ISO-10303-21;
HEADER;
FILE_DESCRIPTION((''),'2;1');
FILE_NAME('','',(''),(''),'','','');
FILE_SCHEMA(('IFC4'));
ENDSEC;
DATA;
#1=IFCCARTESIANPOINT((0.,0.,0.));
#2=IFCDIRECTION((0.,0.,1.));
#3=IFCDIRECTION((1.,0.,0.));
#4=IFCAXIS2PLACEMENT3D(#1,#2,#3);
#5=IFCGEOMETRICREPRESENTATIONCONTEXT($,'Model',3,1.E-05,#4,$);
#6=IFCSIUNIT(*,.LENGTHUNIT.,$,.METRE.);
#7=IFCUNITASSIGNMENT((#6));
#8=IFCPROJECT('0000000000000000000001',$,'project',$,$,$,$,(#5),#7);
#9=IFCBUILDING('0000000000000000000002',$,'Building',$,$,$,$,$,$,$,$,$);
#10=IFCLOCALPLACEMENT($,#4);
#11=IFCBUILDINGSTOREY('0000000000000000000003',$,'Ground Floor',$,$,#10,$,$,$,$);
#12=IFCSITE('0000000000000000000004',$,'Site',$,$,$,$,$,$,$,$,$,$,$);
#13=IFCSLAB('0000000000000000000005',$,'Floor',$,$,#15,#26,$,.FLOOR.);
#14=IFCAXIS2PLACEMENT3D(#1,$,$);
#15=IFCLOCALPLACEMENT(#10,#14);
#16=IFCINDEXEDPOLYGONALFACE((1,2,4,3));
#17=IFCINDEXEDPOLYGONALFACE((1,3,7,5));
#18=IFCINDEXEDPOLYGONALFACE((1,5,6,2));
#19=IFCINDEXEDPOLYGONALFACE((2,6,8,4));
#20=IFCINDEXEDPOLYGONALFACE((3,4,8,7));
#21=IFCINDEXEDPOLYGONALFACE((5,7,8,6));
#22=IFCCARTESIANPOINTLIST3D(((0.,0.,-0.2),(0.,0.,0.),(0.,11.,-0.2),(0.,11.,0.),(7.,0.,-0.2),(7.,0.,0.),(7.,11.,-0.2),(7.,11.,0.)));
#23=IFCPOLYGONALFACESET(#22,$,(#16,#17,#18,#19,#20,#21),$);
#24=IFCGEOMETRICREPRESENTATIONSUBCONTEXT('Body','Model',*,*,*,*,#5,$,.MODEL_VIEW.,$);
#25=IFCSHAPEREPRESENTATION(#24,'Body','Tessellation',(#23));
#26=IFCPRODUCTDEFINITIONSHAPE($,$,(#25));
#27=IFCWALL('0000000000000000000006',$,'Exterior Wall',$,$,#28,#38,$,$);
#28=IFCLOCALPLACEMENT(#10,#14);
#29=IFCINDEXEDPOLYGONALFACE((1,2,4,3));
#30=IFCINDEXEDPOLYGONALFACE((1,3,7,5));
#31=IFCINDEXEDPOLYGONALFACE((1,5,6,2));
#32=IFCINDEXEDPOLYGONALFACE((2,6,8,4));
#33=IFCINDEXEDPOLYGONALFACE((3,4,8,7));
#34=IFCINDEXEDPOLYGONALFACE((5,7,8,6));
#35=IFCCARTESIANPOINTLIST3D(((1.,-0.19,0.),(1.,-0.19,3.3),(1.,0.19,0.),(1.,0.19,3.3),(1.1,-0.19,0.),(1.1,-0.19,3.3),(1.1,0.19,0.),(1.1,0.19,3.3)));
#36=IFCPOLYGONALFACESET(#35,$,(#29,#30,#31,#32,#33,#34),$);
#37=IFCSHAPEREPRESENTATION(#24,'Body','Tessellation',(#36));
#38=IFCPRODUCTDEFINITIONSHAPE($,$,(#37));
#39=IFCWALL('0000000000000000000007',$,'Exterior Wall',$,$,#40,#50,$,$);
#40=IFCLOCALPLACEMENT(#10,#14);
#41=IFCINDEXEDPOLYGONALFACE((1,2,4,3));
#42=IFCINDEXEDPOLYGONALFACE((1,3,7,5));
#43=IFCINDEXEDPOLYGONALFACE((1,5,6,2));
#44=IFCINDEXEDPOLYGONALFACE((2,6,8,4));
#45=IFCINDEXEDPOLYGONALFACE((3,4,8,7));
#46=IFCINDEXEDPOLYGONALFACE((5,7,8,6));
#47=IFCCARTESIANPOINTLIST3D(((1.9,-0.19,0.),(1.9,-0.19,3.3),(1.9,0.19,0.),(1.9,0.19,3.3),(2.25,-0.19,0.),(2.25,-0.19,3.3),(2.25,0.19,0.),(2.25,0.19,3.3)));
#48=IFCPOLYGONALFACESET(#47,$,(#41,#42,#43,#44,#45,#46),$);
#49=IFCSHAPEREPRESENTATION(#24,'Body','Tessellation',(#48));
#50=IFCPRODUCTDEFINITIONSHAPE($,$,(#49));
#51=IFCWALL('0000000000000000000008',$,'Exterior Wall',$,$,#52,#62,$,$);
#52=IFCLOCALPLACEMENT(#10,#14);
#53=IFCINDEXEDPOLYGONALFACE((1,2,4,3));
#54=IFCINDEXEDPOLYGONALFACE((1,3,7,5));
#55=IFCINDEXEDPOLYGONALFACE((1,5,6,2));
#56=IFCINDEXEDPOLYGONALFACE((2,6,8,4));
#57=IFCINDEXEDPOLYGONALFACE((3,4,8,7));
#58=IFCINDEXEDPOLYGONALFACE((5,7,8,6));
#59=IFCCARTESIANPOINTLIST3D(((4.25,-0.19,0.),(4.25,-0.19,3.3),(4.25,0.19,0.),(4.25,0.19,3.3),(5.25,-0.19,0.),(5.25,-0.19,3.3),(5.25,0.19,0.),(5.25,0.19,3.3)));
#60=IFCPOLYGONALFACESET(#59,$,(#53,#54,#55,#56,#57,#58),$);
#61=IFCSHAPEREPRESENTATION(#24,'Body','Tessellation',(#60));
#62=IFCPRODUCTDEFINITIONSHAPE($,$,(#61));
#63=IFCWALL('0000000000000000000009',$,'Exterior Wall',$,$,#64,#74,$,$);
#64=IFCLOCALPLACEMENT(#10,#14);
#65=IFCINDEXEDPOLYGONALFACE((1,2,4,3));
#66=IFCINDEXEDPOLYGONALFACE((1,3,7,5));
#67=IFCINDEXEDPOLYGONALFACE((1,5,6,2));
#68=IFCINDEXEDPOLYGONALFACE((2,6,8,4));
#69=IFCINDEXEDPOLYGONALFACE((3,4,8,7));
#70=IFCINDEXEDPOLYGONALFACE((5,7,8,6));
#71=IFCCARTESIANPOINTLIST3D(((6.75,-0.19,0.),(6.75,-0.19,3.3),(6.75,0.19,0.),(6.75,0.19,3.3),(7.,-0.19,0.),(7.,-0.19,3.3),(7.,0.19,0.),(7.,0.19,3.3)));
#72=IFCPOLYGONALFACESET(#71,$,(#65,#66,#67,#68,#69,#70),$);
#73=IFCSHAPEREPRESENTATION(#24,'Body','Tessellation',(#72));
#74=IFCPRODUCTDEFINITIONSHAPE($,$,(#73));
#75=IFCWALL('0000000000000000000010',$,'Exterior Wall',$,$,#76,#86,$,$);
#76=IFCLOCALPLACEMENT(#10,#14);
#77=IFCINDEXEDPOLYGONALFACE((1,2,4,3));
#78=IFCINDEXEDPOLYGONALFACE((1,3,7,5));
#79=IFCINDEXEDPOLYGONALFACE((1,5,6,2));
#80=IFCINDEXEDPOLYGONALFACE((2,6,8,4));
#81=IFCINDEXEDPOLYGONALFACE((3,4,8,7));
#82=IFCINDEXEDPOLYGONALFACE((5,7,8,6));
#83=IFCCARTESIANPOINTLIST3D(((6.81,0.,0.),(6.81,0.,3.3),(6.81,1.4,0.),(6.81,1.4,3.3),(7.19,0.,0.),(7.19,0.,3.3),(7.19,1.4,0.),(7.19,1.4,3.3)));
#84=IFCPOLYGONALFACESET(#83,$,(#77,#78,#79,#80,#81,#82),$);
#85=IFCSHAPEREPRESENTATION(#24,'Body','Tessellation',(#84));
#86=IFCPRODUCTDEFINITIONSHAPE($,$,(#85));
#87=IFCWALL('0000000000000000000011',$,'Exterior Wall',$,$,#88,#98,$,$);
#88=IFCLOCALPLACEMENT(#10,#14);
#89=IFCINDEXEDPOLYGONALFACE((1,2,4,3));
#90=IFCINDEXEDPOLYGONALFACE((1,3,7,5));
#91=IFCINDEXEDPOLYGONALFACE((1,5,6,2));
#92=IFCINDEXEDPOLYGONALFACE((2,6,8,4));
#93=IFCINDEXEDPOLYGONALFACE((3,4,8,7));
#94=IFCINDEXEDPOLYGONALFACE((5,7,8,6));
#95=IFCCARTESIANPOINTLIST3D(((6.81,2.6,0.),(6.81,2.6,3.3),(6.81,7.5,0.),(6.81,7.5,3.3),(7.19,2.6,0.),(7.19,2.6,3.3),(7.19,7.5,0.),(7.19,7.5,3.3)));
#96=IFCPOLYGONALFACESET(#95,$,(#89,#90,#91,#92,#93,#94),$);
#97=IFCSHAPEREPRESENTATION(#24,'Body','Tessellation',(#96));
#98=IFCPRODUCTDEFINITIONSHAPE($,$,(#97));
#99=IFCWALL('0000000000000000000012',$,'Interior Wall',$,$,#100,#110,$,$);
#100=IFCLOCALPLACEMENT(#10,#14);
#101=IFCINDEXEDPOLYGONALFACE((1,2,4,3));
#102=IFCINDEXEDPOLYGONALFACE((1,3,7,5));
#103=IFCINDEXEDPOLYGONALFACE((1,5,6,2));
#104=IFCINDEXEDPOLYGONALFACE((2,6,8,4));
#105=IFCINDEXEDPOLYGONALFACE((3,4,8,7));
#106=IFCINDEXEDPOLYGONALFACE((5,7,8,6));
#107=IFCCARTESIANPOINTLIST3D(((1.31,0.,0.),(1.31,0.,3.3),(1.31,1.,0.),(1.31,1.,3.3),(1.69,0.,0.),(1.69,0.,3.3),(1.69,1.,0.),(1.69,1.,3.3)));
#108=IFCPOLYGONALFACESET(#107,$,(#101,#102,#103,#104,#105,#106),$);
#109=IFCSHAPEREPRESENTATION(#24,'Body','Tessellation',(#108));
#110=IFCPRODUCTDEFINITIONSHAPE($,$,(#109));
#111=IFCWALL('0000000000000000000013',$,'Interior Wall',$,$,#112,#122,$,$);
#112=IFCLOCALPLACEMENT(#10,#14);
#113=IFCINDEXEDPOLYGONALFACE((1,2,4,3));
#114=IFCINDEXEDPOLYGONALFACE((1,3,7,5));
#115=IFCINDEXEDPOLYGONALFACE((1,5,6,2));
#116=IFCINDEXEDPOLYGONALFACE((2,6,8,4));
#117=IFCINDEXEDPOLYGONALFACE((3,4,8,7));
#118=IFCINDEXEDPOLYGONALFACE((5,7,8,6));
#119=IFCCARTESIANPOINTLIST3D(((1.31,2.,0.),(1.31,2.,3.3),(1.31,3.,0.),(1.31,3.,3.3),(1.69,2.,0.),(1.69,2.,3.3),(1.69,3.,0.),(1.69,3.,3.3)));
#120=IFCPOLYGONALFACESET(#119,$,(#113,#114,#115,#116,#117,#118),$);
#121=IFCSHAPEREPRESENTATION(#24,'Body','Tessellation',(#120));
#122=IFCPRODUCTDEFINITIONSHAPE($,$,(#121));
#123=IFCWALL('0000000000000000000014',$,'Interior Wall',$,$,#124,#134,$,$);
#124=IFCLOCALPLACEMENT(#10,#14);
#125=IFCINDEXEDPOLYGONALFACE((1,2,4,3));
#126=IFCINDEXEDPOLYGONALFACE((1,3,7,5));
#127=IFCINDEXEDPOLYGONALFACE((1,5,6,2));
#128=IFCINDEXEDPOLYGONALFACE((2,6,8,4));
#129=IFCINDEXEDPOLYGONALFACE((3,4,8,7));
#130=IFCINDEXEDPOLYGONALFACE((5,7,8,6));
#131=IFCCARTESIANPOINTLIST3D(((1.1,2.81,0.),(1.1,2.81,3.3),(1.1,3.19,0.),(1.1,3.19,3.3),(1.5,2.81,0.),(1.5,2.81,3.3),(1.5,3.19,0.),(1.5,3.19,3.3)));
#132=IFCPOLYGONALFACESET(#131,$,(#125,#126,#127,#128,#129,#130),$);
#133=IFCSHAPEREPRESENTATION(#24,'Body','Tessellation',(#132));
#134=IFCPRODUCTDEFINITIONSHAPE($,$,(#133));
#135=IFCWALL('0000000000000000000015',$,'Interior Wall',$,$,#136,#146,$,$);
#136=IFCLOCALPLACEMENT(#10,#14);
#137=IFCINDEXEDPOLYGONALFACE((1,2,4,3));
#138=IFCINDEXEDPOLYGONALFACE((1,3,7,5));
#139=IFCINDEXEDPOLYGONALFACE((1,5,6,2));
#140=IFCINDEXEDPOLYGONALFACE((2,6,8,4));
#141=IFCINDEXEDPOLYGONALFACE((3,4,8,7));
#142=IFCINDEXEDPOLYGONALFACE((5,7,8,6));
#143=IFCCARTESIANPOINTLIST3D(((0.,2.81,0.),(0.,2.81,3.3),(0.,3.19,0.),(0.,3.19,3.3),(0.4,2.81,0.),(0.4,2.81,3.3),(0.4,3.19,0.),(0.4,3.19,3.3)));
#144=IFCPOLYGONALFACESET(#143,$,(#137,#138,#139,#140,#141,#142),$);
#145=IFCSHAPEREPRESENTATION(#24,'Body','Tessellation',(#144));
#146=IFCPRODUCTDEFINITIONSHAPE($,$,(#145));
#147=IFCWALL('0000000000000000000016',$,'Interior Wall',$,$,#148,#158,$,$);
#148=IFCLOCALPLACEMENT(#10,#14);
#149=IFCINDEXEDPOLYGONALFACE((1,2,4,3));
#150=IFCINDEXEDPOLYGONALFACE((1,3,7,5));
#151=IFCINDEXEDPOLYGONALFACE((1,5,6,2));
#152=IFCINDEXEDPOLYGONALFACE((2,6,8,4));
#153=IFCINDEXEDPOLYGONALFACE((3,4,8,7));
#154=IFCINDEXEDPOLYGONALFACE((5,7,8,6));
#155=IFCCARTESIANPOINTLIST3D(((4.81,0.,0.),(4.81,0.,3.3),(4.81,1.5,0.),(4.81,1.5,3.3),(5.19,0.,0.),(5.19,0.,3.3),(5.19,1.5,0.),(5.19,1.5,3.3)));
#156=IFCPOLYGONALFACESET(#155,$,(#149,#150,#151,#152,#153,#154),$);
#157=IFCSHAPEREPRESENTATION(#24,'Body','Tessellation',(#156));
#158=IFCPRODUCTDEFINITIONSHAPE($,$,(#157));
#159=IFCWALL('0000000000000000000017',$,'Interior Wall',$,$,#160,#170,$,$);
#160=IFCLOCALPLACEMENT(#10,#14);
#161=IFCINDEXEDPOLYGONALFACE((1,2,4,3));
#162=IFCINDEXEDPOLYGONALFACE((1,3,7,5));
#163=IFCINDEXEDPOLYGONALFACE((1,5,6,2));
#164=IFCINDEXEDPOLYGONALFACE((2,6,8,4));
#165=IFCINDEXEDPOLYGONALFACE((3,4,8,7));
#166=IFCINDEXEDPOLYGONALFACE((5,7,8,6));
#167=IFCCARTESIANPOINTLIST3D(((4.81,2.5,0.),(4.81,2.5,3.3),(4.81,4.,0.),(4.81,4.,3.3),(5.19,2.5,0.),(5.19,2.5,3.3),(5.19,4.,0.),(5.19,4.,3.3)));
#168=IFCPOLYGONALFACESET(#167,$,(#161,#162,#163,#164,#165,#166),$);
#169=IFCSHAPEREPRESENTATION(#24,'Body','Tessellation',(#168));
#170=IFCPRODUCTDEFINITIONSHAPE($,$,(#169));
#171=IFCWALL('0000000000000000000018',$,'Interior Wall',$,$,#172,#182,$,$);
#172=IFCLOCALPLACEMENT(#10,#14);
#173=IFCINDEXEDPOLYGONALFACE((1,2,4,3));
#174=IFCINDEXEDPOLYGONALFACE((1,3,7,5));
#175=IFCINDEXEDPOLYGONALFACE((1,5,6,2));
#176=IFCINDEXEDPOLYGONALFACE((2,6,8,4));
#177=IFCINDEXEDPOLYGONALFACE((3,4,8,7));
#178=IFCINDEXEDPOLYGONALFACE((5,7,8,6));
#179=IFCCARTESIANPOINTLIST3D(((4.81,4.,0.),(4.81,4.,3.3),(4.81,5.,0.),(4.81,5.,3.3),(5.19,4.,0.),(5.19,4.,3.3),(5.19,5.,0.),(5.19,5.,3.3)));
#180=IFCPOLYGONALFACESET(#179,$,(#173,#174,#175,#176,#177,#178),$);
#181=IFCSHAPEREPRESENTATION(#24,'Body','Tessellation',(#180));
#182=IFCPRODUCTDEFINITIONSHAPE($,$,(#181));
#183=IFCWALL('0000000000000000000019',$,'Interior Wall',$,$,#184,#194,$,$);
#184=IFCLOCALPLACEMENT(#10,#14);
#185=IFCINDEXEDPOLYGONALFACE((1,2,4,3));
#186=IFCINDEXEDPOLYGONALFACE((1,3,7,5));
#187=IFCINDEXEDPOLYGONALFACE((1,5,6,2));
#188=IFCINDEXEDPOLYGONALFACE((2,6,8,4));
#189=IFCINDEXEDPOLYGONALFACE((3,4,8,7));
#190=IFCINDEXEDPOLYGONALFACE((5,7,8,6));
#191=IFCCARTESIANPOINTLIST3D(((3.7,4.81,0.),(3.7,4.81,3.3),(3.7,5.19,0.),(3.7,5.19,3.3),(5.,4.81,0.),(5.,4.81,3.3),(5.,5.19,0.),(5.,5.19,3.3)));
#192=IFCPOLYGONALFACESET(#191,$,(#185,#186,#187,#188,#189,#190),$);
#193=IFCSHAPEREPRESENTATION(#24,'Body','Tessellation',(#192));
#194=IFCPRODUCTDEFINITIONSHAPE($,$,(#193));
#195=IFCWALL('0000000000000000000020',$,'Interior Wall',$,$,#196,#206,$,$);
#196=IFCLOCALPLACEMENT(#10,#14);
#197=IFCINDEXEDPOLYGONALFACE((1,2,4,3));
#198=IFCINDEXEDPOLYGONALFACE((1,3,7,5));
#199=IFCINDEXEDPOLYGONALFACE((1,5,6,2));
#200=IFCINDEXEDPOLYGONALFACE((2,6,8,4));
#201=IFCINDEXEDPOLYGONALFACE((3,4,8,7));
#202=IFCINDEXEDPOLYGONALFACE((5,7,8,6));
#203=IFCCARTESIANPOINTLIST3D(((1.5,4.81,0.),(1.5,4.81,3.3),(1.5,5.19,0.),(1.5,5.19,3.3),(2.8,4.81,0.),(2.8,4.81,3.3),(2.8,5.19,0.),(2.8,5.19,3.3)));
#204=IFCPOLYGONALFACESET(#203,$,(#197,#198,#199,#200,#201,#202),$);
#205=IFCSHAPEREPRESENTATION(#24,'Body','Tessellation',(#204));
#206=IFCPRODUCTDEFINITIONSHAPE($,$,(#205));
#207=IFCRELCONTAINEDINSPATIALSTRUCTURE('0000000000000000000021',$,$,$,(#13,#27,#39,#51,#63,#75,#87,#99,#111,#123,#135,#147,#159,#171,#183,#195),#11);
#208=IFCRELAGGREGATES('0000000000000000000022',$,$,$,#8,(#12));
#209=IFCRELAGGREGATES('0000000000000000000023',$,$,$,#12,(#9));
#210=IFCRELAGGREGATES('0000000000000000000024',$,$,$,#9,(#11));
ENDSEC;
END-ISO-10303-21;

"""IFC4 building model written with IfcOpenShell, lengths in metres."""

from ifc_helpers import new_model, si_unit, frame, origin_with_axes, place, context, subcontext, project, spatial, indexed_curve, outline, extrude, element, save


model = new_model("IFC4")

# Units and contexts
model_context = context("Model", 3, precision=1e-05, world=origin_with_axes())
body_context = subcontext(model_context, "Body", "Model", "MODEL_VIEW")
ifc_project = project(units=[si_unit("LENGTHUNIT", "METRE")], contexts=[model_context])

# Site, building, storey
site = spatial("IfcSite", under=ifc_project, Name="Site")
building = spatial("IfcBuilding", under=site, Name="Building")
storey_placement = place(None, origin_with_axes())
storey = spatial("IfcBuildingStorey", under=building, at=storey_placement, Name="Ground Floor")

# Slab
slab_placement = place(storey_placement, frame((0.0, 0.0, -0.2), z_axis=(0.0, 0.0, 1.0), x_axis=(1.0, 0.0, 0.0)))
element("IfcSlab", 1, at=slab_placement, inside=storey, Name="Floor", PredefinedType="FLOOR", context=body_context, shape_type="SweptSolid", body=[
    extrude(outline(indexed_curve([(0.0, 0.0), (7.0, 0.0), (7.0, 11.0), (0.0, 11.0)])), None, (0.0, 0.0, 1.0), 0.2),
])

# Walls
wall_1_placement = place(storey_placement, frame((1.0, 0.0, 0.0), z_axis=(0.0, 0.0, 1.0), x_axis=(1.0, 0.0, 0.0)))
element("IfcWall", 2, at=wall_1_placement, inside=storey, Name="Exterior Wall", context=body_context, shape_type="SweptSolid", body=[
    extrude(outline(indexed_curve([(0.0, 0.0), (0.0, 0.38), (0.1, 0.38), (0.1, 0.0), (0.0, 0.0)], self_intersect=False)), frame((0.0, -0.19, 0.0), z_axis=(0.0, 0.0, 1.0), x_axis=(1.0, 0.0, 0.0)), (0.0, 0.0, 1.0), 3.3),
])
wall_2_placement = place(storey_placement, frame((1.9, 0.0, 0.0), z_axis=(0.0, 0.0, 1.0), x_axis=(1.0, 0.0, 0.0)))
element("IfcWall", 3, at=wall_2_placement, inside=storey, Name="Exterior Wall", context=body_context, shape_type="SweptSolid", body=[
    extrude(outline(indexed_curve([(0.0, 0.0), (0.0, 0.38), (0.35, 0.38), (0.35, 0.0), (0.0, 0.0)], self_intersect=False)), frame((0.0, -0.19, 0.0), z_axis=(0.0, 0.0, 1.0), x_axis=(1.0, 0.0, 0.0)), (0.0, 0.0, 1.0), 3.3),
])
wall_3_placement = place(storey_placement, frame((4.25, 0.0, 0.0), z_axis=(0.0, 0.0, 1.0), x_axis=(1.0, 0.0, 0.0)))
element("IfcWall", 4, at=wall_3_placement, inside=storey, Name="Exterior Wall", context=body_context, shape_type="SweptSolid", body=[
    extrude(outline(indexed_curve([(0.0, 0.0), (0.0, 0.38), (1.0, 0.38), (1.0, 0.0), (0.0, 0.0)], self_intersect=False)), frame((0.0, -0.19, 0.0), z_axis=(0.0, 0.0, 1.0), x_axis=(1.0, 0.0, 0.0)), (0.0, 0.0, 1.0), 3.3),
])
wall_4_placement = place(storey_placement, frame((6.75, 0.0, 0.0), z_axis=(0.0, 0.0, 1.0), x_axis=(1.0, 0.0, 0.0)))
element("IfcWall", 5, at=wall_4_placement, inside=storey, Name="Exterior Wall", context=body_context, shape_type="SweptSolid", body=[
    extrude(outline(indexed_curve([(0.0, 0.0), (0.0, 0.38), (0.25, 0.38), (0.25, 0.0), (0.0, 0.0)], self_intersect=False)), frame((0.0, -0.19, 0.0), z_axis=(0.0, 0.0, 1.0), x_axis=(1.0, 0.0, 0.0)), (0.0, 0.0, 1.0), 3.3),
])
wall_5_placement = place(storey_placement, frame((7.0, 0.0, 0.0), z_axis=(0.0, 0.0, 1.0), x_axis=(0.0, 1.0, 0.0)))
element("IfcWall", 6, at=wall_5_placement, inside=storey, Name="Exterior Wall", context=body_context, shape_type="SweptSolid", body=[
    extrude(outline(indexed_curve([(0.0, 0.0), (0.0, 0.38), (1.4, 0.38), (1.4, 0.0), (0.0, 0.0)], self_intersect=False)), frame((0.0, -0.19, 0.0), z_axis=(0.0, 0.0, 1.0), x_axis=(1.0, 0.0, 0.0)), (0.0, 0.0, 1.0), 3.3),
])
wall_6_placement = place(storey_placement, frame((7.0, 2.6, 0.0), z_axis=(0.0, 0.0, 1.0), x_axis=(0.0, 1.0, 0.0)))
element("IfcWall", 7, at=wall_6_placement, inside=storey, Name="Exterior Wall", context=body_context, shape_type="SweptSolid", body=[
    extrude(outline(indexed_curve([(0.0, 0.0), (0.0, 0.38), (4.9, 0.38), (4.9, 0.0), (0.0, 0.0)], self_intersect=False)), frame((0.0, -0.19, 0.0), z_axis=(0.0, 0.0, 1.0), x_axis=(1.0, 0.0, 0.0)), (0.0, 0.0, 1.0), 3.3),
])
for number, where, z_axis, x_axis, name in (
    (8, (1.5, 0.0, 0.0), (0.0, 0.0, 1.0), (0.0, 1.0, 0.0), "Interior Wall"),
    (9, (1.5, 2.0, 0.0), (0.0, 0.0, 1.0), (0.0, 1.0, 0.0), "Interior Wall"),
):
    element("IfcWall", number, at=place(storey_placement, frame(where, z_axis=z_axis, x_axis=x_axis)), inside=storey, Name=name, context=body_context, shape_type="SweptSolid", body=[
        extrude(outline(indexed_curve([(0.0, 0.0), (0.0, 0.38), (1.0, 0.38), (1.0, 0.0), (0.0, 0.0)], self_intersect=False)), frame((0.0, -0.19, 0.0), z_axis=(0.0, 0.0, 1.0), x_axis=(1.0, 0.0, 0.0)), (0.0, 0.0, 1.0), 3.3),
    ])
for number, where, z_axis, x_axis, name in (
    (10, (1.5, 3.0, 0.0), (0.0, 0.0, 1.0), (-1.0, 0.0, 0.0), "Interior Wall"),
    (11, (0.4, 3.0, 0.0), (0.0, 0.0, 1.0), (-1.0, 0.0, 0.0), "Interior Wall"),
):
    element("IfcWall", number, at=place(storey_placement, frame(where, z_axis=z_axis, x_axis=x_axis)), inside=storey, Name=name, context=body_context, shape_type="SweptSolid", body=[
        extrude(outline(indexed_curve([(0.0, 0.0), (0.0, 0.38), (0.4, 0.38), (0.4, 0.0), (0.0, 0.0)], self_intersect=False)), frame((0.0, -0.19, 0.0), z_axis=(0.0, 0.0, 1.0), x_axis=(1.0, 0.0, 0.0)), (0.0, 0.0, 1.0), 3.3),
    ])
for number, where, z_axis, x_axis, name in (
    (12, (5.0, 0.0, 0.0), (0.0, 0.0, 1.0), (0.0, 1.0, 0.0), "Interior Wall"),
    (13, (5.0, 2.5, 0.0), (0.0, 0.0, 1.0), (0.0, 1.0, 0.0), "Interior Wall"),
):
    element("IfcWall", number, at=place(storey_placement, frame(where, z_axis=z_axis, x_axis=x_axis)), inside=storey, Name=name, context=body_context, shape_type="SweptSolid", body=[
        extrude(outline(indexed_curve([(0.0, 0.0), (0.0, 0.38), (1.5, 0.38), (1.5, 0.0), (0.0, 0.0)], self_intersect=False)), frame((0.0, -0.19, 0.0), z_axis=(0.0, 0.0, 1.0), x_axis=(1.0, 0.0, 0.0)), (0.0, 0.0, 1.0), 3.3),
    ])
wall_7_placement = place(storey_placement, frame((5.0, 4.0, 0.0), z_axis=(0.0, 0.0, 1.0), x_axis=(0.0, 1.0, 0.0)))
element("IfcWall", 14, at=wall_7_placement, inside=storey, Name="Interior Wall", context=body_context, shape_type="SweptSolid", body=[
    extrude(outline(indexed_curve([(0.0, 0.0), (0.0, 0.38), (1.0, 0.38), (1.0, 0.0), (0.0, 0.0)], self_intersect=False)), frame((0.0, -0.19, 0.0), z_axis=(0.0, 0.0, 1.0), x_axis=(1.0, 0.0, 0.0)), (0.0, 0.0, 1.0), 3.3),
])
for number, where, z_axis, x_axis, name in (
    (15, (5.0, 5.0, 0.0), (0.0, 0.0, 1.0), (-1.0, 0.0, 0.0), "Interior Wall"),
    (16, (2.8, 5.0, 0.0), (0.0, 0.0, 1.0), (-1.0, 0.0, 0.0), "Interior Wall"),
):
    element("IfcWall", number, at=place(storey_placement, frame(where, z_axis=z_axis, x_axis=x_axis)), inside=storey, Name=name, context=body_context, shape_type="SweptSolid", body=[
        extrude(outline(indexed_curve([(0.0, 0.0), (0.0, 0.38), (1.3, 0.38), (1.3, 0.0), (0.0, 0.0)], self_intersect=False)), frame((0.0, -0.19, 0.0), z_axis=(0.0, 0.0, 1.0), x_axis=(1.0, 0.0, 0.0)), (0.0, 0.0, 1.0), 3.3),
    ])

save(model, "model.ifc")
